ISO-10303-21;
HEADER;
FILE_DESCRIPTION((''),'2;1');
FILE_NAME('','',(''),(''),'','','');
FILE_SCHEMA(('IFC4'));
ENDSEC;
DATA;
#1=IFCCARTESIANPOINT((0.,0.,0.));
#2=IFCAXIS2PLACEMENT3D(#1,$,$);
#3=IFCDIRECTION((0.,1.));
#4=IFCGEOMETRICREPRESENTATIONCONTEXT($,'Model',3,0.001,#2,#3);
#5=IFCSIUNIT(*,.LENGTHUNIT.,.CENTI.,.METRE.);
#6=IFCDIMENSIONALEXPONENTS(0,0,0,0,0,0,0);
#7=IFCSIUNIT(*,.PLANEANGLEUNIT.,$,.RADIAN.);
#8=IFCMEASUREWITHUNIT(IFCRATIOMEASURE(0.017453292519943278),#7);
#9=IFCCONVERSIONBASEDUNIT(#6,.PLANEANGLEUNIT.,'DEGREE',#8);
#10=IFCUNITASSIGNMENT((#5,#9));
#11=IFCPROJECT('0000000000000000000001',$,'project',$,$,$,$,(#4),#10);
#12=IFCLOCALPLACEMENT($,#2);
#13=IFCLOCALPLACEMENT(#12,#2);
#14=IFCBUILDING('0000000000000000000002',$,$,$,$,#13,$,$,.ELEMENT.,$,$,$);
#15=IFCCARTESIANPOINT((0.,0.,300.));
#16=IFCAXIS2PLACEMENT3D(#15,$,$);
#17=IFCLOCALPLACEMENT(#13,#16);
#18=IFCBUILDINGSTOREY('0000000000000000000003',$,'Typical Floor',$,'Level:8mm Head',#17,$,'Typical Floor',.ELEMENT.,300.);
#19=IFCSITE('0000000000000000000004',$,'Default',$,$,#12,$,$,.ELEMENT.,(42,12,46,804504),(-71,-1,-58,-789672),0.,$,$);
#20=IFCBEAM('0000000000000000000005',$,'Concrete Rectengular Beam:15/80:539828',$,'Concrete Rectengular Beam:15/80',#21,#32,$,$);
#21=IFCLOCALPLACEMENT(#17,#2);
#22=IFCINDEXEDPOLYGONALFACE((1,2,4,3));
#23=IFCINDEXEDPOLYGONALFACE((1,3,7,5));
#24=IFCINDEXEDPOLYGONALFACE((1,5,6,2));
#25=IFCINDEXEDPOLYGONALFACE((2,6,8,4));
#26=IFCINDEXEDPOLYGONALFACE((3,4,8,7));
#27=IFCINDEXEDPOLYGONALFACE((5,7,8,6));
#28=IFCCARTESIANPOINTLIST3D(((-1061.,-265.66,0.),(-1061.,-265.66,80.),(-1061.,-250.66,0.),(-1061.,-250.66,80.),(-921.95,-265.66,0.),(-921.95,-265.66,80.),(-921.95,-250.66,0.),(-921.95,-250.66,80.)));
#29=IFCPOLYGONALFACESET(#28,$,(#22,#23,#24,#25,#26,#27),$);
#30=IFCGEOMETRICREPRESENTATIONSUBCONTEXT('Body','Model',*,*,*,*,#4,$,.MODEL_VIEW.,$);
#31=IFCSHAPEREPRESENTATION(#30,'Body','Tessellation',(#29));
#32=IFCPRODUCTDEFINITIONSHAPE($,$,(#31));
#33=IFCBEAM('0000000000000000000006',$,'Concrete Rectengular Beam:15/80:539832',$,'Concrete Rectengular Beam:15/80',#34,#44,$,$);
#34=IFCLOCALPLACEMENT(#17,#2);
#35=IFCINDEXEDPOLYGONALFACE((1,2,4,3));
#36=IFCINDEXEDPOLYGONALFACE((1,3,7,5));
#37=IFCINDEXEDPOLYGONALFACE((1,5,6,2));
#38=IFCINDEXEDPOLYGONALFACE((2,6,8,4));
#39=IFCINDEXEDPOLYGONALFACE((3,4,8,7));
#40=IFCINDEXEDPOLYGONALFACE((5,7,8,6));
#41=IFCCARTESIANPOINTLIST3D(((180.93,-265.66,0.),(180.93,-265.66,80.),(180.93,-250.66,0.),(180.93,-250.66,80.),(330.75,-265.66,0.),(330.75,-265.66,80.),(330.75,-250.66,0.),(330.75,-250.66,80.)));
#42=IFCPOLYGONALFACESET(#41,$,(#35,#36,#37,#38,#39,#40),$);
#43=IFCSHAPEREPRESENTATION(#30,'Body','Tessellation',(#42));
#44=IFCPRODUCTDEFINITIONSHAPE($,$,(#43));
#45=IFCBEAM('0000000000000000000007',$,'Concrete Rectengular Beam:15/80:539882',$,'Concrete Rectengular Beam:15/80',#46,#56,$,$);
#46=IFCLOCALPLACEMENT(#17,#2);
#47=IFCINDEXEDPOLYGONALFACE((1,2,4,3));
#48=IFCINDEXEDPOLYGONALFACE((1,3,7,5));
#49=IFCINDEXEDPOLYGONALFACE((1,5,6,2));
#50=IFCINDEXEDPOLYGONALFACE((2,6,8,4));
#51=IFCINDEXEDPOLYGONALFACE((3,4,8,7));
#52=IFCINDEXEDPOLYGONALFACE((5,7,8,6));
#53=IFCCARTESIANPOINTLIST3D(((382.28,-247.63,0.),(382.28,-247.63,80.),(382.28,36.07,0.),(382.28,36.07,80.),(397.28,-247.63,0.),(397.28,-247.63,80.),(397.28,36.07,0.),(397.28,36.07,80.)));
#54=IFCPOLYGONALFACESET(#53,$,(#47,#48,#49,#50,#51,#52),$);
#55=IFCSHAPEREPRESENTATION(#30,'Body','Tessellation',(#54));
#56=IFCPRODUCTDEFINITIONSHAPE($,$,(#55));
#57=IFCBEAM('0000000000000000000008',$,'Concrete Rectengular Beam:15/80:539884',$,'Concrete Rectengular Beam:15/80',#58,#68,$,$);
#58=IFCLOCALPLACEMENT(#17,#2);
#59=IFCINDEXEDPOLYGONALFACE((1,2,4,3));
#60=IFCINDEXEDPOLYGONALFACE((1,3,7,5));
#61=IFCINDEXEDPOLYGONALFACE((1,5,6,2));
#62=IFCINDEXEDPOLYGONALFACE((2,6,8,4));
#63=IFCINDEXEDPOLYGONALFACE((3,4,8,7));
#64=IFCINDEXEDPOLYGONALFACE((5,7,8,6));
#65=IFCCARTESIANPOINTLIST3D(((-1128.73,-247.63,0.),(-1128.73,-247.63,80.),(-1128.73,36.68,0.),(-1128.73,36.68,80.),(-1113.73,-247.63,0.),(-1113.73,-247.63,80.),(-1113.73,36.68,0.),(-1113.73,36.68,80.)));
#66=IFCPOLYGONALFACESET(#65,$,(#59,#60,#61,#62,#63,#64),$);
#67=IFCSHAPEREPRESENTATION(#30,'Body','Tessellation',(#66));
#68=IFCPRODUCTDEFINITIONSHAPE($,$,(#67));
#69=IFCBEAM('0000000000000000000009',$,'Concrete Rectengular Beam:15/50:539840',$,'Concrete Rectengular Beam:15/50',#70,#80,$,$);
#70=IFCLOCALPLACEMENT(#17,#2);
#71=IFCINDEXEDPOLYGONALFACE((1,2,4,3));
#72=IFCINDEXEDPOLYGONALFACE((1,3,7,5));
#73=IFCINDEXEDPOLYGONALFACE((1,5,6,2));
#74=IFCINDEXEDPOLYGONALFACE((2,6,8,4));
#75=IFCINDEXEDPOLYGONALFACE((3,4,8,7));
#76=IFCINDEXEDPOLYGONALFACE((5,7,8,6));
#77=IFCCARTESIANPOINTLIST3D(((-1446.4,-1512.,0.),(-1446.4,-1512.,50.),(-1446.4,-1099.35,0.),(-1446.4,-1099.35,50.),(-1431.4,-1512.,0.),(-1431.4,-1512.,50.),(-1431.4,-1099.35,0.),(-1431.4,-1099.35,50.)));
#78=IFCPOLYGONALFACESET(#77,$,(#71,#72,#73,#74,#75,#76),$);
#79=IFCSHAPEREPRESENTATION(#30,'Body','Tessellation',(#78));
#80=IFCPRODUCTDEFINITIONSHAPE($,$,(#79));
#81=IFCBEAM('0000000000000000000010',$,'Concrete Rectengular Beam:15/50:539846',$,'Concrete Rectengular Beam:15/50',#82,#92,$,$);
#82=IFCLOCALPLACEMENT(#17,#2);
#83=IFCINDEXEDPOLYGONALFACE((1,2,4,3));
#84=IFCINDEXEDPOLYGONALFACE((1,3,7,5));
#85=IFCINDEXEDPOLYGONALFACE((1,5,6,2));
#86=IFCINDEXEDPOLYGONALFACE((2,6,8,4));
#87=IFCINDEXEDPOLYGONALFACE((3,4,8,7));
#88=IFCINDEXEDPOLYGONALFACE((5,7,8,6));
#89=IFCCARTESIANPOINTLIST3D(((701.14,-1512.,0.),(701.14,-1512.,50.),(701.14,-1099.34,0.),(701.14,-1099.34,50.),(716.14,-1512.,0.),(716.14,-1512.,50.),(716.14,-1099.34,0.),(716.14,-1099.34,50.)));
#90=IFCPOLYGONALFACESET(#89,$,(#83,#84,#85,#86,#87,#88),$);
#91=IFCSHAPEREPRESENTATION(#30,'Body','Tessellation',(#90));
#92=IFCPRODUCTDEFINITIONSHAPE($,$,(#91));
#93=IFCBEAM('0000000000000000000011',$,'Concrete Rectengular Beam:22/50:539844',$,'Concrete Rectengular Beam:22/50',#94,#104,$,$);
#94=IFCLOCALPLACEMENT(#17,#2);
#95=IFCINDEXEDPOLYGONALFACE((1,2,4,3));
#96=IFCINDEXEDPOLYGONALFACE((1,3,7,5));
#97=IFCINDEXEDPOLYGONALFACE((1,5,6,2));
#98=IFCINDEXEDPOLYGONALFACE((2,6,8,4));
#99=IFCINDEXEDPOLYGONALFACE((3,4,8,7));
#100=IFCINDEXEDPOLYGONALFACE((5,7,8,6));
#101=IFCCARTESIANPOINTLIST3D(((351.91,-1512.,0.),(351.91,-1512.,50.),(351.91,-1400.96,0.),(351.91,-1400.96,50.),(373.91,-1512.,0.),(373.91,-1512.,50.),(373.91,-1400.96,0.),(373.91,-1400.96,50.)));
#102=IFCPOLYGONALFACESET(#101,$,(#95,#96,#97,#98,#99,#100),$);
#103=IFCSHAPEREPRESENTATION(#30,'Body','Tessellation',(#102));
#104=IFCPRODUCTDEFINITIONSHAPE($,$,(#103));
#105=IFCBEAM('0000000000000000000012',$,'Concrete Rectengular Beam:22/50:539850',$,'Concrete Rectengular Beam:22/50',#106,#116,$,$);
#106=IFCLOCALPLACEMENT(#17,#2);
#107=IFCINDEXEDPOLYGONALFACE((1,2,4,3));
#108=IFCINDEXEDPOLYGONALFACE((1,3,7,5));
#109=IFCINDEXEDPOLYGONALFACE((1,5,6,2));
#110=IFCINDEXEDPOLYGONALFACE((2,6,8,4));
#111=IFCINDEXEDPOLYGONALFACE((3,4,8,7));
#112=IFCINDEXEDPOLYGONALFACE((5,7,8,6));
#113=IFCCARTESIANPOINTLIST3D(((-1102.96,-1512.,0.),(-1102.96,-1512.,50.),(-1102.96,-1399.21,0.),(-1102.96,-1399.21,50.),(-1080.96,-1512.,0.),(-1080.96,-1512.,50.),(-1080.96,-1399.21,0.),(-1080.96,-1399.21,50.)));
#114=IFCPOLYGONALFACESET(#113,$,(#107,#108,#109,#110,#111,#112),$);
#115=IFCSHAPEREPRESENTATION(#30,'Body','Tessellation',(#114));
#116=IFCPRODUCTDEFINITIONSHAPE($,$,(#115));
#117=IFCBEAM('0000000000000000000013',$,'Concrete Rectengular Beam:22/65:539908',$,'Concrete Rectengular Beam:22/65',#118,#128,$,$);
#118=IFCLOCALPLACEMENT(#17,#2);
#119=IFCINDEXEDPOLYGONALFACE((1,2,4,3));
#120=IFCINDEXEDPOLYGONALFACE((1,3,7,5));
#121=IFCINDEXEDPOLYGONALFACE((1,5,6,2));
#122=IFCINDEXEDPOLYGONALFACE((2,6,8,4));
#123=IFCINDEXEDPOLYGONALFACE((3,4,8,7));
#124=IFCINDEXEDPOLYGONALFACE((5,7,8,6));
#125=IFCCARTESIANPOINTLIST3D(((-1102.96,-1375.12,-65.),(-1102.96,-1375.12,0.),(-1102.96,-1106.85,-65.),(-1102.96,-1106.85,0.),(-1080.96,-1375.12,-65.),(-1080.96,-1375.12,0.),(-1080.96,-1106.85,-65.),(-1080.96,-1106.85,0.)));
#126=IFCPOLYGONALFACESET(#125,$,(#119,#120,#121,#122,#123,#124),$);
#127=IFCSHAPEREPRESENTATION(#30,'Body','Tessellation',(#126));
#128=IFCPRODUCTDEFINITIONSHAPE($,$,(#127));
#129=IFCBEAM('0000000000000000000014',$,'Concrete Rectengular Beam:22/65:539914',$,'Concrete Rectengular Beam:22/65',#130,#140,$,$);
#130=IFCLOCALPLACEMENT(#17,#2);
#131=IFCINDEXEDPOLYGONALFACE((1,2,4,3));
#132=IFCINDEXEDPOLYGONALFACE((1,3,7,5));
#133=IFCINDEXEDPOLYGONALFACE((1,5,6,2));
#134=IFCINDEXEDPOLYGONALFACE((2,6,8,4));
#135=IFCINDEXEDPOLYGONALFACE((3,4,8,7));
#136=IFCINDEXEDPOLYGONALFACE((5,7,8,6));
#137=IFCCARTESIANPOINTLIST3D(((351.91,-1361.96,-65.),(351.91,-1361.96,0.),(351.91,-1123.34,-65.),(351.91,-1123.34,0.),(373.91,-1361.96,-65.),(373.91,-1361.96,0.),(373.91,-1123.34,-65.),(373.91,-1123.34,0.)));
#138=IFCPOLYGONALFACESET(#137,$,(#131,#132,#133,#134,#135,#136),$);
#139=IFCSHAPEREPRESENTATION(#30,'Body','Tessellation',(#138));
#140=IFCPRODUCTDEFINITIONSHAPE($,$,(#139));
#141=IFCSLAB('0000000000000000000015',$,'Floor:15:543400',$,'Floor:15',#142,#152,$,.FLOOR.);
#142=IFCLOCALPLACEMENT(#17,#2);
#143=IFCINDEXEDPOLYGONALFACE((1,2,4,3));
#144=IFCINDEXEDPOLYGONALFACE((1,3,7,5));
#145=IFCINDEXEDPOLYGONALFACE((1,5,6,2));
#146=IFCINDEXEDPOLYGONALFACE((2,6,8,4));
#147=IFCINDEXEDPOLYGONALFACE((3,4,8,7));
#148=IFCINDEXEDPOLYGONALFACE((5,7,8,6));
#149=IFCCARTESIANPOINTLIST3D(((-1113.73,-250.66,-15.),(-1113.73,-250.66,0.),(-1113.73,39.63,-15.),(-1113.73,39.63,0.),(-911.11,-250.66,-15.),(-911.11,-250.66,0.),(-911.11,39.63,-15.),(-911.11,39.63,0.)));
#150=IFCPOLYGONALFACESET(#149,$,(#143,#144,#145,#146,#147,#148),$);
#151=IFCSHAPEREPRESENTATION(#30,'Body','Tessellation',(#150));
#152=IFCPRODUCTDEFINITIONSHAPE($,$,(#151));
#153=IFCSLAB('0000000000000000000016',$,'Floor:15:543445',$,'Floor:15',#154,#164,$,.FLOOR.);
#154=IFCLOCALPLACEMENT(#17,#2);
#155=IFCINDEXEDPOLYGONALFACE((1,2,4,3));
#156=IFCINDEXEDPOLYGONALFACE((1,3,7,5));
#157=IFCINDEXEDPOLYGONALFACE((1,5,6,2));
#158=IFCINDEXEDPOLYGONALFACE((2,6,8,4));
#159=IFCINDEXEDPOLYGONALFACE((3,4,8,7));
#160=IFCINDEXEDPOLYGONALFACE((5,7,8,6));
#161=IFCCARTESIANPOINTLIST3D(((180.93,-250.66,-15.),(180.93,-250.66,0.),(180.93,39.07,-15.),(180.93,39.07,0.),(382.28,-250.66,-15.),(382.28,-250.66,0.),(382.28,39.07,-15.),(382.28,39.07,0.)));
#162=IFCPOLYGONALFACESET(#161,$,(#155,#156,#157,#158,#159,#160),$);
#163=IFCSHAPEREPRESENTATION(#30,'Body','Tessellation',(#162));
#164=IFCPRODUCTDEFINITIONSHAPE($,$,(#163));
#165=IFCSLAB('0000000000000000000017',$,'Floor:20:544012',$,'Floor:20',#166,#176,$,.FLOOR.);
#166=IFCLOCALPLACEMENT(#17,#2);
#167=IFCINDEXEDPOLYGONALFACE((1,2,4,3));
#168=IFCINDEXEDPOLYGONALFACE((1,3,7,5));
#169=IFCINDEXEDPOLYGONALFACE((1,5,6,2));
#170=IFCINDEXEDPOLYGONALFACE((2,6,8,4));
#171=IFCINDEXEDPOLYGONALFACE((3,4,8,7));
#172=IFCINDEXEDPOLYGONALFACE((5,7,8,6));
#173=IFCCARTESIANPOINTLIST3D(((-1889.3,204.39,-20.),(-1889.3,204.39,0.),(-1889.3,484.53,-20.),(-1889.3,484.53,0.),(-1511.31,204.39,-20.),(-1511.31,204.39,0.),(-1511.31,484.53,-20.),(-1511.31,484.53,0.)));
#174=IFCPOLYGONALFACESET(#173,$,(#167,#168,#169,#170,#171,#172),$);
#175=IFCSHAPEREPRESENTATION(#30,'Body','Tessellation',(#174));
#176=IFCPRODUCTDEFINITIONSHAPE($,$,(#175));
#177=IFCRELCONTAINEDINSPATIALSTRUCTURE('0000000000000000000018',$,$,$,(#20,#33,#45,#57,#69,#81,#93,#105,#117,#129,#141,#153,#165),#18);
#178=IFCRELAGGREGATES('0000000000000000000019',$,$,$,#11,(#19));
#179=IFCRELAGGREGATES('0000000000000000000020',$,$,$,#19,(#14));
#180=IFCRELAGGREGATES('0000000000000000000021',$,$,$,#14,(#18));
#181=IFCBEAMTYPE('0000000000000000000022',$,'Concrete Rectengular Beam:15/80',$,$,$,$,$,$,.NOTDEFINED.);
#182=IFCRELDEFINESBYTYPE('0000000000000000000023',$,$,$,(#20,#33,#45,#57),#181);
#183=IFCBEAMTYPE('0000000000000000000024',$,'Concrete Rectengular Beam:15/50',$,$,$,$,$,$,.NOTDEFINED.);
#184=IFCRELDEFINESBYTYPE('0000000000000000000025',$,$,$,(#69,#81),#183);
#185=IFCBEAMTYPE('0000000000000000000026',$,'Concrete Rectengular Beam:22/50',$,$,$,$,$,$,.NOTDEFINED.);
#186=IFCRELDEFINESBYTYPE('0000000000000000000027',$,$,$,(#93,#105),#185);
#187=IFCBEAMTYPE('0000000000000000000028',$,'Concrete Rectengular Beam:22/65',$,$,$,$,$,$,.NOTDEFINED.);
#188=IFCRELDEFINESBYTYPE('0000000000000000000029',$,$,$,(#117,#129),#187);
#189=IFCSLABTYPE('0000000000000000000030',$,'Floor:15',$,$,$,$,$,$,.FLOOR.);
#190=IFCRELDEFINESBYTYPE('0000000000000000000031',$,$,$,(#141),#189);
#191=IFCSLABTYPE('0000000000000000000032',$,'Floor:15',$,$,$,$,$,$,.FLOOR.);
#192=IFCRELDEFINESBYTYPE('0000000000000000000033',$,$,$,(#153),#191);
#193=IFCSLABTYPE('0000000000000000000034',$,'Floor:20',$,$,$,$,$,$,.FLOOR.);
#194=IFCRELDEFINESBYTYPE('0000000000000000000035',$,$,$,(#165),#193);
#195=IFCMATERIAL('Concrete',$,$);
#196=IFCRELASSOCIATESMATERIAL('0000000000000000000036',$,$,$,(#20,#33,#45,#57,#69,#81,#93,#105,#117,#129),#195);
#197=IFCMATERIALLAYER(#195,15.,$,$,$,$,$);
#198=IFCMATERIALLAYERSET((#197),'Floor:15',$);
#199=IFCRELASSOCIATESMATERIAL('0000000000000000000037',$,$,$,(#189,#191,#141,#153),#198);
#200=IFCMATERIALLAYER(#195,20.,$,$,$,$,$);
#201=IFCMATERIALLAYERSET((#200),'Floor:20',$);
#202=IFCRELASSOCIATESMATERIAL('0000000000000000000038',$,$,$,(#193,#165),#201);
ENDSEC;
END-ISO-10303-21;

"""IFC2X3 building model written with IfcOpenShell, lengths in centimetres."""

from ifc_helpers import new_model, entity, si_unit, converted_unit, direction, frame, frame_2d, origin, origin_2d_with_axis, place, context, subcontext, project, spatial, rectangle, extrude, material, layer, layer_set, layer_usage, type_object, element, save


model = new_model("IFC2X3")

# Units and contexts
model_context = context("Model", 3, precision=0.001, world=origin(), true_north=direction((0.0, 1.0)))
body_context = subcontext(model_context, "Body", "Model", "MODEL_VIEW")
ifc_project = project(units=[si_unit("LENGTHUNIT", "METRE", prefix="CENTI"), converted_unit("PLANEANGLEUNIT", "DEGREE", entity("IfcRatioMeasure", 0.017453292519943278), si_unit("PLANEANGLEUNIT", "RADIAN"), dimensions=[0, 0, 0, 0, 0, 0, 0])], contexts=[model_context])

# Site, building, storey
site_placement = place(None, origin())
site = spatial("IfcSite", under=ifc_project, at=site_placement, Name="Default", CompositionType="ELEMENT", RefLatitude=(42, 12, 46, 804504), RefLongitude=(-71, -1, -58, -789672), RefElevation=0.0)
building_placement = place(site_placement, origin())
building = spatial("IfcBuilding", under=site, at=building_placement, CompositionType="ELEMENT")
storey_placement = place(building_placement, frame((0.0, 0.0, 300.0)))
storey = spatial("IfcBuildingStorey", under=building, at=storey_placement, Name="Typical Floor", ObjectType="Level:8mm Head", LongName="Typical Floor", CompositionType="ELEMENT", Elevation=300.0)

# Beams
ifc_material_1 = material(Name="Concrete")
beam_type_1 = type_object("IfcBeamType", Name="Concrete Rectengular Beam:15/80", PredefinedType="NOTDEFINED")
beam_1_placement = place(storey_placement, frame((-1061.0, -258.16, 0.0)))
element("IfcBeam", 1, at=beam_1_placement, inside=storey, type_object=beam_type_1, material=ifc_material_1, Name="Concrete Rectengular Beam:15/80:539828", ObjectType="Concrete Rectengular Beam:15/80", context=body_context, shape_type="SweptSolid", body=[
    extrude(rectangle(XDim=80.0, YDim=15.0, at=frame_2d((0.0, 0.0), x_axis=(1.0, 0.0))), frame((0.0, 0.0, 40.0), z_axis=(1.0, 0.0, 0.0), x_axis=(0.0, 0.0, -1.0)), (0.0, 0.0, 1.0), 139.05),
])
beam_2_placement = place(storey_placement, frame((330.75, -258.16, 0.0), z_axis=(0.0, 0.0, 1.0), x_axis=(-1.0, 0.0, 0.0)))
element("IfcBeam", 2, at=beam_2_placement, inside=storey, type_object=beam_type_1, material=ifc_material_1, Name="Concrete Rectengular Beam:15/80:539832", ObjectType="Concrete Rectengular Beam:15/80", context=body_context, shape_type="SweptSolid", body=[
    extrude(rectangle(XDim=80.0, YDim=15.0, at=frame_2d((0.0, 0.0), x_axis=(1.0, 0.0))), frame((0.0, 0.0, 40.0), z_axis=(1.0, 0.0, 0.0), x_axis=(0.0, 0.0, -1.0)), (0.0, 0.0, 1.0), 149.82),
])
beam_3_placement = place(storey_placement, frame((397.28, -247.63, 0.0), z_axis=(0.0, 0.0, 1.0), x_axis=(0.0, 1.0, 0.0)))
element("IfcBeam", 3, at=beam_3_placement, inside=storey, type_object=beam_type_1, material=ifc_material_1, Name="Concrete Rectengular Beam:15/80:539882", ObjectType="Concrete Rectengular Beam:15/80", context=body_context, shape_type="SweptSolid", body=[
    extrude(rectangle(XDim=80.0, YDim=15.0, at=origin_2d_with_axis()), frame((0.0, 7.5, 40.0), z_axis=(1.0, 0.0, 0.0), x_axis=(0.0, 0.0, -1.0)), (0.0, 0.0, 1.0), 283.7),
])
beam_4_placement = place(storey_placement, frame((-1128.73, -247.63, 0.0), z_axis=(0.0, 0.0, 1.0), x_axis=(0.0, 1.0, 0.0)))
element("IfcBeam", 4, at=beam_4_placement, inside=storey, type_object=beam_type_1, material=ifc_material_1, Name="Concrete Rectengular Beam:15/80:539884", ObjectType="Concrete Rectengular Beam:15/80", context=body_context, shape_type="SweptSolid", body=[
    extrude(rectangle(XDim=80.0, YDim=15.0, at=origin_2d_with_axis()), frame((0.0, -7.5, 40.0), z_axis=(1.0, 0.0, 0.0), x_axis=(0.0, 0.0, -1.0)), (0.0, 0.0, 1.0), 284.3),
])
beam_type_2 = type_object("IfcBeamType", Name="Concrete Rectengular Beam:15/50", PredefinedType="NOTDEFINED")
beam_5_placement = place(storey_placement, frame((-1438.9, -1497.0, 0.0), z_axis=(0.0, 0.0, 1.0), x_axis=(0.0, 1.0, 0.0)))
element("IfcBeam", 5, at=beam_5_placement, inside=storey, type_object=beam_type_2, material=ifc_material_1, Name="Concrete Rectengular Beam:15/50:539840", ObjectType="Concrete Rectengular Beam:15/50", context=body_context, shape_type="SweptSolid", body=[
    extrude(rectangle(XDim=50.0, YDim=15.0, at=frame_2d((0.0, 0.0), x_axis=(1.0, 0.0))), frame((-15.0, 0.0, 25.0), z_axis=(1.0, 0.0, 0.0), x_axis=(0.0, 0.0, -1.0)), (0.0, 0.0, 1.0), 412.66),
])
beam_6_placement = place(storey_placement, frame((708.64, -1497.0, 0.0), z_axis=(0.0, 0.0, 1.0), x_axis=(0.0, 1.0, 0.0)))
element("IfcBeam", 6, at=beam_6_placement, inside=storey, type_object=beam_type_2, material=ifc_material_1, Name="Concrete Rectengular Beam:15/50:539846", ObjectType="Concrete Rectengular Beam:15/50", context=body_context, shape_type="SweptSolid", body=[
    extrude(rectangle(XDim=50.0, YDim=15.0, at=frame_2d((0.0, 0.0), x_axis=(1.0, 0.0))), frame((-15.0, 0.0, 25.0), z_axis=(1.0, 0.0, 0.0), x_axis=(0.0, 0.0, -1.0)), (0.0, 0.0, 1.0), 412.66),
])
beam_type_3 = type_object("IfcBeamType", Name="Concrete Rectengular Beam:22/50", PredefinedType="NOTDEFINED")
beam_7_placement = place(storey_placement, frame((362.91, -1400.96, 0.0), z_axis=(0.0, 0.0, 1.0), x_axis=(0.0, -1.0, 0.0)))
element("IfcBeam", 7, at=beam_7_placement, inside=storey, type_object=beam_type_3, material=ifc_material_1, Name="Concrete Rectengular Beam:22/50:539844", ObjectType="Concrete Rectengular Beam:22/50", context=body_context, shape_type="SweptSolid", body=[
    extrude(rectangle(XDim=50.0, YDim=22.0, at=frame_2d((0.0, 0.0), x_axis=(1.0, 0.0))), frame((0.0, 0.0, 25.0), z_axis=(1.0, 0.0, 0.0), x_axis=(0.0, 0.0, -1.0)), (0.0, 0.0, 1.0), 111.04),
])
beam_8_placement = place(storey_placement, frame((-1091.96, -1399.21, 0.0), z_axis=(0.0, 0.0, 1.0), x_axis=(0.0, -1.0, 0.0)))
element("IfcBeam", 8, at=beam_8_placement, inside=storey, type_object=beam_type_3, material=ifc_material_1, Name="Concrete Rectengular Beam:22/50:539850", ObjectType="Concrete Rectengular Beam:22/50", context=body_context, shape_type="SweptSolid", body=[
    extrude(rectangle(XDim=50.0, YDim=22.0, at=frame_2d((0.0, 0.0), x_axis=(1.0, 0.0))), frame((0.0, 0.0, 25.0), z_axis=(1.0, 0.0, 0.0), x_axis=(0.0, 0.0, -1.0)), (0.0, 0.0, 1.0), 112.79),
])
beam_type_4 = type_object("IfcBeamType", Name="Concrete Rectengular Beam:22/65", PredefinedType="NOTDEFINED")
beam_9_placement = place(storey_placement, frame((-1091.96, -1375.12, 0.0), z_axis=(0.0, 0.0, 1.0), x_axis=(0.0, 1.0, 0.0)))
element("IfcBeam", 9, at=beam_9_placement, inside=storey, type_object=beam_type_4, material=ifc_material_1, Name="Concrete Rectengular Beam:22/65:539908", ObjectType="Concrete Rectengular Beam:22/65", context=body_context, shape_type="SweptSolid", body=[
    extrude(rectangle(XDim=65.0, YDim=22.0, at=frame_2d((0.0, 0.0), x_axis=(1.0, 0.0))), frame((0.0, 0.0, -32.5), z_axis=(1.0, 0.0, 0.0), x_axis=(0.0, 0.0, -1.0)), (0.0, 0.0, 1.0), 268.27),
])
beam_10_placement = place(storey_placement, frame((362.91, -1123.34, 0.0), z_axis=(0.0, 0.0, 1.0), x_axis=(0.0, -1.0, 0.0)))
element("IfcBeam", 10, at=beam_10_placement, inside=storey, type_object=beam_type_4, material=ifc_material_1, Name="Concrete Rectengular Beam:22/65:539914", ObjectType="Concrete Rectengular Beam:22/65", context=body_context, shape_type="SweptSolid", body=[
    extrude(rectangle(XDim=65.0, YDim=22.0, at=frame_2d((0.0, 0.0), x_axis=(1.0, 0.0))), frame((0.0, 0.0, -32.5), z_axis=(1.0, 0.0, 0.0), x_axis=(0.0, 0.0, -1.0)), (0.0, 0.0, 1.0), 238.61),
])

# Slabs
ifc_layer_1 = layer(ifc_material_1, 20.0)
ifc_layer_set_1 = layer_set([ifc_layer_1], Name="Floor:20")
ifc_layer_2 = layer(ifc_material_1, 15.0)
ifc_layer_set_2 = layer_set([ifc_layer_2], Name="Floor:15")
ifc_layer_usage_1 = layer_usage(ifc_layer_set_2, "AXIS3", "POSITIVE", 0.0)
slab_type_1 = type_object("IfcSlabType", Name="Floor:15", PredefinedType="FLOOR", material=ifc_layer_set_2)
slab_1_placement = place(storey_placement, origin())
element("IfcSlab", 11, at=slab_1_placement, inside=storey, type_object=slab_type_1, material=ifc_layer_usage_1, Name="Floor:15:543400", ObjectType="Floor:15", PredefinedType="FLOOR", context=body_context, shape_type="SweptSolid", body=[
    extrude(rectangle(XDim=290.28, YDim=202.63, at=frame_2d((0.0, 0.0), x_axis=(1.0, 0.0))), frame((-1012.42, -105.51, 0.0), z_axis=(0.0, 0.0, -1.0), x_axis=(0.0, 1.0, 0.0)), (0.0, 0.0, 1.0), 15.0),
])
ifc_layer_usage_2 = layer_usage(ifc_layer_set_2, "AXIS3", "POSITIVE", 0.0)
slab_type_2 = type_object("IfcSlabType", Name="Floor:15", PredefinedType="FLOOR", material=ifc_layer_set_2)
slab_2_placement = place(storey_placement, origin())
element("IfcSlab", 12, at=slab_2_placement, inside=storey, type_object=slab_type_2, material=ifc_layer_usage_2, Name="Floor:15:543445", ObjectType="Floor:15", PredefinedType="FLOOR", context=body_context, shape_type="SweptSolid", body=[
    extrude(rectangle(XDim=289.72, YDim=201.35, at=frame_2d((0.0, 0.0), x_axis=(1.0, 0.0))), frame((281.61, -105.79, 0.0), z_axis=(0.0, 0.0, -1.0), x_axis=(0.0, 1.0, 0.0)), (0.0, 0.0, 1.0), 15.0),
])
ifc_layer_usage_3 = layer_usage(ifc_layer_set_1, "AXIS3", "POSITIVE", 0.0)
slab_type_3 = type_object("IfcSlabType", Name="Floor:20", PredefinedType="FLOOR", material=ifc_layer_set_1)
slab_3_placement = place(storey_placement, origin())
element("IfcSlab", 13, at=slab_3_placement, inside=storey, type_object=slab_type_3, material=ifc_layer_usage_3, Name="Floor:20:544012", ObjectType="Floor:20", PredefinedType="FLOOR", context=body_context, shape_type="SweptSolid", body=[
    extrude(rectangle(XDim=280.14, YDim=377.99, at=frame_2d((0.0, 0.0), x_axis=(1.0, 0.0))), frame((-1700.31, 344.46, 0.0), z_axis=(0.0, 0.0, -1.0), x_axis=(0.0, 1.0, 0.0)), (0.0, 0.0, 1.0), 20.0),
])

save(model, "model.ifc")
